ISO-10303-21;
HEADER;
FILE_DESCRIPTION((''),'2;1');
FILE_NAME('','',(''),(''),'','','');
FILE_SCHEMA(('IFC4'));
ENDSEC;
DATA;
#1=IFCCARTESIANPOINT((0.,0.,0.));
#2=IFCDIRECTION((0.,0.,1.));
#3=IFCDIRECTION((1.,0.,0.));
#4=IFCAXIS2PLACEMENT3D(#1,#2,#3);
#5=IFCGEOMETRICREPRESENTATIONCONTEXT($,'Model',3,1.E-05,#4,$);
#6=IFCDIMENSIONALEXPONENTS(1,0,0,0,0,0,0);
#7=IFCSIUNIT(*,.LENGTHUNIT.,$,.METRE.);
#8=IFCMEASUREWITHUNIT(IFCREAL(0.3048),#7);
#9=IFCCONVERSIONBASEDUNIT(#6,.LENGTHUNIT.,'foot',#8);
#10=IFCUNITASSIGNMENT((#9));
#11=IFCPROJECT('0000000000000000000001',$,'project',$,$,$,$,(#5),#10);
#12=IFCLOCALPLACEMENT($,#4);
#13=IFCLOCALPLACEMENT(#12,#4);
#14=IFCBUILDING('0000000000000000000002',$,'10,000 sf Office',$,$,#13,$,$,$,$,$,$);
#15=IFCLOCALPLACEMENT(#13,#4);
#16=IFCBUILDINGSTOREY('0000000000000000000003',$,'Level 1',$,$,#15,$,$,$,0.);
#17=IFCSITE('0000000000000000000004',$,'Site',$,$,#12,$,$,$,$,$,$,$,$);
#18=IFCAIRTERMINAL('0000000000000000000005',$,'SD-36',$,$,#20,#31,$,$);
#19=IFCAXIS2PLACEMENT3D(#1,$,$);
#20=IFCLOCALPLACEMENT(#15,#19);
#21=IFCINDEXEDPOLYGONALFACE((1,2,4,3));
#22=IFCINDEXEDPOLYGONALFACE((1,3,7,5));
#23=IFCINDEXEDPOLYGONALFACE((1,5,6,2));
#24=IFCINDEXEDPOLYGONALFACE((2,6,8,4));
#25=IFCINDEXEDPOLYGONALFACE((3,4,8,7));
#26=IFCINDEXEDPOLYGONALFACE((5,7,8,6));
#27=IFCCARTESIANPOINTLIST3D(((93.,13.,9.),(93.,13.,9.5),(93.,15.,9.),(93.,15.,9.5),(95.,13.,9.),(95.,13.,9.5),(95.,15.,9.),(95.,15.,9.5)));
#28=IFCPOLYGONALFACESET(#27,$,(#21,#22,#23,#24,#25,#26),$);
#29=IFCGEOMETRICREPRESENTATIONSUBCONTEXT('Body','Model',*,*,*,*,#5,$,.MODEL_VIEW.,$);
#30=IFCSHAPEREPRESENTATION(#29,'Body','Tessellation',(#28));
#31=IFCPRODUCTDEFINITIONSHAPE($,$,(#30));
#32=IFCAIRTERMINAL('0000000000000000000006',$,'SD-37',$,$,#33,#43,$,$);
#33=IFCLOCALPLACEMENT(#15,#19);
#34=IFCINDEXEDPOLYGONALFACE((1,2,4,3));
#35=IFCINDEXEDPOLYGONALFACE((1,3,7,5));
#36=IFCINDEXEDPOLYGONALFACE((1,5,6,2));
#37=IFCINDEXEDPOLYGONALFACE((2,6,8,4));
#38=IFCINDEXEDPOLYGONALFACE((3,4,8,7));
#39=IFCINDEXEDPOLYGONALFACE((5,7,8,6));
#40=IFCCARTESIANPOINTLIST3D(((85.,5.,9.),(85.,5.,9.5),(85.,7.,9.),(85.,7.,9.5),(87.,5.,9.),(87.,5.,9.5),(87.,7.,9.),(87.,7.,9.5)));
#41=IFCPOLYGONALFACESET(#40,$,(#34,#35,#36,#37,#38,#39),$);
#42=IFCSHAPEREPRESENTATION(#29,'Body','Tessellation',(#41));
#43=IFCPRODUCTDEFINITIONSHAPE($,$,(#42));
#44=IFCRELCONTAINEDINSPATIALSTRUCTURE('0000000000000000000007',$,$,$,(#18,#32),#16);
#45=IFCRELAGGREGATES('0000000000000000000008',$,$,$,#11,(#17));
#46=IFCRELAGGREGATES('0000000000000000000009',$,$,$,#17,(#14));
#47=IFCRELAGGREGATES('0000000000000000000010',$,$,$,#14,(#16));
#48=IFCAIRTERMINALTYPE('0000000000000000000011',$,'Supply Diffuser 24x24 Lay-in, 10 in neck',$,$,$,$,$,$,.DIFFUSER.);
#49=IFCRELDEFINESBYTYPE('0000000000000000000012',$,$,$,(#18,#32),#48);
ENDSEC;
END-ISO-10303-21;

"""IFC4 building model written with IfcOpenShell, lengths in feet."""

from ifc_helpers import new_model, entity, si_unit, converted_unit, frame, origin_with_axes, place, context, subcontext, project, spatial, rectangle, extrude, type_object, element, save


model = new_model("IFC4")

# Units and contexts
model_context = context("Model", 3, precision=1e-05, world=origin_with_axes())
body_context = subcontext(model_context, "Body", "Model", "MODEL_VIEW")
ifc_project = project(units=[converted_unit("LENGTHUNIT", "foot", entity("IfcReal", 0.3048), si_unit("LENGTHUNIT", "METRE"), dimensions=[1, 0, 0, 0, 0, 0, 0])], contexts=[model_context])

# Site, building, storey
site_placement = place(None, origin_with_axes())
site = spatial("IfcSite", under=ifc_project, at=site_placement, Name="Site")
building_placement = place(site_placement, origin_with_axes())
building = spatial("IfcBuilding", under=site, at=building_placement, Name="10,000 sf Office")
storey_placement = place(building_placement, origin_with_axes())
storey = spatial("IfcBuildingStorey", under=building, at=storey_placement, Name="Level 1", Elevation=0.0)

# Air terminals
air_terminal_type_1 = type_object("IfcAirTerminalType", Name="Supply Diffuser 24x24 Lay-in, 10 in neck", PredefinedType="DIFFUSER")
for number, where, z_axis, x_axis, name in (
    (1, (94.0, 14.0, 9.0), (0.0, 0.0, 1.0), (1.0, 0.0, 0.0), "SD-36"),
    (2, (86.0, 6.0, 9.0), (0.0, 0.0, 1.0), (1.0, 0.0, 0.0), "SD-37"),
):
    element("IfcAirTerminal", number, at=place(storey_placement, frame(where, z_axis=z_axis, x_axis=x_axis)), inside=storey, type_object=air_terminal_type_1, Name=name, context=body_context, shape_type="SweptSolid", body=[
        extrude(rectangle(XDim=2.0, YDim=2.0), None, (0.0, 0.0, 1.0), 0.5),
    ])

save(model, "model.ifc")
